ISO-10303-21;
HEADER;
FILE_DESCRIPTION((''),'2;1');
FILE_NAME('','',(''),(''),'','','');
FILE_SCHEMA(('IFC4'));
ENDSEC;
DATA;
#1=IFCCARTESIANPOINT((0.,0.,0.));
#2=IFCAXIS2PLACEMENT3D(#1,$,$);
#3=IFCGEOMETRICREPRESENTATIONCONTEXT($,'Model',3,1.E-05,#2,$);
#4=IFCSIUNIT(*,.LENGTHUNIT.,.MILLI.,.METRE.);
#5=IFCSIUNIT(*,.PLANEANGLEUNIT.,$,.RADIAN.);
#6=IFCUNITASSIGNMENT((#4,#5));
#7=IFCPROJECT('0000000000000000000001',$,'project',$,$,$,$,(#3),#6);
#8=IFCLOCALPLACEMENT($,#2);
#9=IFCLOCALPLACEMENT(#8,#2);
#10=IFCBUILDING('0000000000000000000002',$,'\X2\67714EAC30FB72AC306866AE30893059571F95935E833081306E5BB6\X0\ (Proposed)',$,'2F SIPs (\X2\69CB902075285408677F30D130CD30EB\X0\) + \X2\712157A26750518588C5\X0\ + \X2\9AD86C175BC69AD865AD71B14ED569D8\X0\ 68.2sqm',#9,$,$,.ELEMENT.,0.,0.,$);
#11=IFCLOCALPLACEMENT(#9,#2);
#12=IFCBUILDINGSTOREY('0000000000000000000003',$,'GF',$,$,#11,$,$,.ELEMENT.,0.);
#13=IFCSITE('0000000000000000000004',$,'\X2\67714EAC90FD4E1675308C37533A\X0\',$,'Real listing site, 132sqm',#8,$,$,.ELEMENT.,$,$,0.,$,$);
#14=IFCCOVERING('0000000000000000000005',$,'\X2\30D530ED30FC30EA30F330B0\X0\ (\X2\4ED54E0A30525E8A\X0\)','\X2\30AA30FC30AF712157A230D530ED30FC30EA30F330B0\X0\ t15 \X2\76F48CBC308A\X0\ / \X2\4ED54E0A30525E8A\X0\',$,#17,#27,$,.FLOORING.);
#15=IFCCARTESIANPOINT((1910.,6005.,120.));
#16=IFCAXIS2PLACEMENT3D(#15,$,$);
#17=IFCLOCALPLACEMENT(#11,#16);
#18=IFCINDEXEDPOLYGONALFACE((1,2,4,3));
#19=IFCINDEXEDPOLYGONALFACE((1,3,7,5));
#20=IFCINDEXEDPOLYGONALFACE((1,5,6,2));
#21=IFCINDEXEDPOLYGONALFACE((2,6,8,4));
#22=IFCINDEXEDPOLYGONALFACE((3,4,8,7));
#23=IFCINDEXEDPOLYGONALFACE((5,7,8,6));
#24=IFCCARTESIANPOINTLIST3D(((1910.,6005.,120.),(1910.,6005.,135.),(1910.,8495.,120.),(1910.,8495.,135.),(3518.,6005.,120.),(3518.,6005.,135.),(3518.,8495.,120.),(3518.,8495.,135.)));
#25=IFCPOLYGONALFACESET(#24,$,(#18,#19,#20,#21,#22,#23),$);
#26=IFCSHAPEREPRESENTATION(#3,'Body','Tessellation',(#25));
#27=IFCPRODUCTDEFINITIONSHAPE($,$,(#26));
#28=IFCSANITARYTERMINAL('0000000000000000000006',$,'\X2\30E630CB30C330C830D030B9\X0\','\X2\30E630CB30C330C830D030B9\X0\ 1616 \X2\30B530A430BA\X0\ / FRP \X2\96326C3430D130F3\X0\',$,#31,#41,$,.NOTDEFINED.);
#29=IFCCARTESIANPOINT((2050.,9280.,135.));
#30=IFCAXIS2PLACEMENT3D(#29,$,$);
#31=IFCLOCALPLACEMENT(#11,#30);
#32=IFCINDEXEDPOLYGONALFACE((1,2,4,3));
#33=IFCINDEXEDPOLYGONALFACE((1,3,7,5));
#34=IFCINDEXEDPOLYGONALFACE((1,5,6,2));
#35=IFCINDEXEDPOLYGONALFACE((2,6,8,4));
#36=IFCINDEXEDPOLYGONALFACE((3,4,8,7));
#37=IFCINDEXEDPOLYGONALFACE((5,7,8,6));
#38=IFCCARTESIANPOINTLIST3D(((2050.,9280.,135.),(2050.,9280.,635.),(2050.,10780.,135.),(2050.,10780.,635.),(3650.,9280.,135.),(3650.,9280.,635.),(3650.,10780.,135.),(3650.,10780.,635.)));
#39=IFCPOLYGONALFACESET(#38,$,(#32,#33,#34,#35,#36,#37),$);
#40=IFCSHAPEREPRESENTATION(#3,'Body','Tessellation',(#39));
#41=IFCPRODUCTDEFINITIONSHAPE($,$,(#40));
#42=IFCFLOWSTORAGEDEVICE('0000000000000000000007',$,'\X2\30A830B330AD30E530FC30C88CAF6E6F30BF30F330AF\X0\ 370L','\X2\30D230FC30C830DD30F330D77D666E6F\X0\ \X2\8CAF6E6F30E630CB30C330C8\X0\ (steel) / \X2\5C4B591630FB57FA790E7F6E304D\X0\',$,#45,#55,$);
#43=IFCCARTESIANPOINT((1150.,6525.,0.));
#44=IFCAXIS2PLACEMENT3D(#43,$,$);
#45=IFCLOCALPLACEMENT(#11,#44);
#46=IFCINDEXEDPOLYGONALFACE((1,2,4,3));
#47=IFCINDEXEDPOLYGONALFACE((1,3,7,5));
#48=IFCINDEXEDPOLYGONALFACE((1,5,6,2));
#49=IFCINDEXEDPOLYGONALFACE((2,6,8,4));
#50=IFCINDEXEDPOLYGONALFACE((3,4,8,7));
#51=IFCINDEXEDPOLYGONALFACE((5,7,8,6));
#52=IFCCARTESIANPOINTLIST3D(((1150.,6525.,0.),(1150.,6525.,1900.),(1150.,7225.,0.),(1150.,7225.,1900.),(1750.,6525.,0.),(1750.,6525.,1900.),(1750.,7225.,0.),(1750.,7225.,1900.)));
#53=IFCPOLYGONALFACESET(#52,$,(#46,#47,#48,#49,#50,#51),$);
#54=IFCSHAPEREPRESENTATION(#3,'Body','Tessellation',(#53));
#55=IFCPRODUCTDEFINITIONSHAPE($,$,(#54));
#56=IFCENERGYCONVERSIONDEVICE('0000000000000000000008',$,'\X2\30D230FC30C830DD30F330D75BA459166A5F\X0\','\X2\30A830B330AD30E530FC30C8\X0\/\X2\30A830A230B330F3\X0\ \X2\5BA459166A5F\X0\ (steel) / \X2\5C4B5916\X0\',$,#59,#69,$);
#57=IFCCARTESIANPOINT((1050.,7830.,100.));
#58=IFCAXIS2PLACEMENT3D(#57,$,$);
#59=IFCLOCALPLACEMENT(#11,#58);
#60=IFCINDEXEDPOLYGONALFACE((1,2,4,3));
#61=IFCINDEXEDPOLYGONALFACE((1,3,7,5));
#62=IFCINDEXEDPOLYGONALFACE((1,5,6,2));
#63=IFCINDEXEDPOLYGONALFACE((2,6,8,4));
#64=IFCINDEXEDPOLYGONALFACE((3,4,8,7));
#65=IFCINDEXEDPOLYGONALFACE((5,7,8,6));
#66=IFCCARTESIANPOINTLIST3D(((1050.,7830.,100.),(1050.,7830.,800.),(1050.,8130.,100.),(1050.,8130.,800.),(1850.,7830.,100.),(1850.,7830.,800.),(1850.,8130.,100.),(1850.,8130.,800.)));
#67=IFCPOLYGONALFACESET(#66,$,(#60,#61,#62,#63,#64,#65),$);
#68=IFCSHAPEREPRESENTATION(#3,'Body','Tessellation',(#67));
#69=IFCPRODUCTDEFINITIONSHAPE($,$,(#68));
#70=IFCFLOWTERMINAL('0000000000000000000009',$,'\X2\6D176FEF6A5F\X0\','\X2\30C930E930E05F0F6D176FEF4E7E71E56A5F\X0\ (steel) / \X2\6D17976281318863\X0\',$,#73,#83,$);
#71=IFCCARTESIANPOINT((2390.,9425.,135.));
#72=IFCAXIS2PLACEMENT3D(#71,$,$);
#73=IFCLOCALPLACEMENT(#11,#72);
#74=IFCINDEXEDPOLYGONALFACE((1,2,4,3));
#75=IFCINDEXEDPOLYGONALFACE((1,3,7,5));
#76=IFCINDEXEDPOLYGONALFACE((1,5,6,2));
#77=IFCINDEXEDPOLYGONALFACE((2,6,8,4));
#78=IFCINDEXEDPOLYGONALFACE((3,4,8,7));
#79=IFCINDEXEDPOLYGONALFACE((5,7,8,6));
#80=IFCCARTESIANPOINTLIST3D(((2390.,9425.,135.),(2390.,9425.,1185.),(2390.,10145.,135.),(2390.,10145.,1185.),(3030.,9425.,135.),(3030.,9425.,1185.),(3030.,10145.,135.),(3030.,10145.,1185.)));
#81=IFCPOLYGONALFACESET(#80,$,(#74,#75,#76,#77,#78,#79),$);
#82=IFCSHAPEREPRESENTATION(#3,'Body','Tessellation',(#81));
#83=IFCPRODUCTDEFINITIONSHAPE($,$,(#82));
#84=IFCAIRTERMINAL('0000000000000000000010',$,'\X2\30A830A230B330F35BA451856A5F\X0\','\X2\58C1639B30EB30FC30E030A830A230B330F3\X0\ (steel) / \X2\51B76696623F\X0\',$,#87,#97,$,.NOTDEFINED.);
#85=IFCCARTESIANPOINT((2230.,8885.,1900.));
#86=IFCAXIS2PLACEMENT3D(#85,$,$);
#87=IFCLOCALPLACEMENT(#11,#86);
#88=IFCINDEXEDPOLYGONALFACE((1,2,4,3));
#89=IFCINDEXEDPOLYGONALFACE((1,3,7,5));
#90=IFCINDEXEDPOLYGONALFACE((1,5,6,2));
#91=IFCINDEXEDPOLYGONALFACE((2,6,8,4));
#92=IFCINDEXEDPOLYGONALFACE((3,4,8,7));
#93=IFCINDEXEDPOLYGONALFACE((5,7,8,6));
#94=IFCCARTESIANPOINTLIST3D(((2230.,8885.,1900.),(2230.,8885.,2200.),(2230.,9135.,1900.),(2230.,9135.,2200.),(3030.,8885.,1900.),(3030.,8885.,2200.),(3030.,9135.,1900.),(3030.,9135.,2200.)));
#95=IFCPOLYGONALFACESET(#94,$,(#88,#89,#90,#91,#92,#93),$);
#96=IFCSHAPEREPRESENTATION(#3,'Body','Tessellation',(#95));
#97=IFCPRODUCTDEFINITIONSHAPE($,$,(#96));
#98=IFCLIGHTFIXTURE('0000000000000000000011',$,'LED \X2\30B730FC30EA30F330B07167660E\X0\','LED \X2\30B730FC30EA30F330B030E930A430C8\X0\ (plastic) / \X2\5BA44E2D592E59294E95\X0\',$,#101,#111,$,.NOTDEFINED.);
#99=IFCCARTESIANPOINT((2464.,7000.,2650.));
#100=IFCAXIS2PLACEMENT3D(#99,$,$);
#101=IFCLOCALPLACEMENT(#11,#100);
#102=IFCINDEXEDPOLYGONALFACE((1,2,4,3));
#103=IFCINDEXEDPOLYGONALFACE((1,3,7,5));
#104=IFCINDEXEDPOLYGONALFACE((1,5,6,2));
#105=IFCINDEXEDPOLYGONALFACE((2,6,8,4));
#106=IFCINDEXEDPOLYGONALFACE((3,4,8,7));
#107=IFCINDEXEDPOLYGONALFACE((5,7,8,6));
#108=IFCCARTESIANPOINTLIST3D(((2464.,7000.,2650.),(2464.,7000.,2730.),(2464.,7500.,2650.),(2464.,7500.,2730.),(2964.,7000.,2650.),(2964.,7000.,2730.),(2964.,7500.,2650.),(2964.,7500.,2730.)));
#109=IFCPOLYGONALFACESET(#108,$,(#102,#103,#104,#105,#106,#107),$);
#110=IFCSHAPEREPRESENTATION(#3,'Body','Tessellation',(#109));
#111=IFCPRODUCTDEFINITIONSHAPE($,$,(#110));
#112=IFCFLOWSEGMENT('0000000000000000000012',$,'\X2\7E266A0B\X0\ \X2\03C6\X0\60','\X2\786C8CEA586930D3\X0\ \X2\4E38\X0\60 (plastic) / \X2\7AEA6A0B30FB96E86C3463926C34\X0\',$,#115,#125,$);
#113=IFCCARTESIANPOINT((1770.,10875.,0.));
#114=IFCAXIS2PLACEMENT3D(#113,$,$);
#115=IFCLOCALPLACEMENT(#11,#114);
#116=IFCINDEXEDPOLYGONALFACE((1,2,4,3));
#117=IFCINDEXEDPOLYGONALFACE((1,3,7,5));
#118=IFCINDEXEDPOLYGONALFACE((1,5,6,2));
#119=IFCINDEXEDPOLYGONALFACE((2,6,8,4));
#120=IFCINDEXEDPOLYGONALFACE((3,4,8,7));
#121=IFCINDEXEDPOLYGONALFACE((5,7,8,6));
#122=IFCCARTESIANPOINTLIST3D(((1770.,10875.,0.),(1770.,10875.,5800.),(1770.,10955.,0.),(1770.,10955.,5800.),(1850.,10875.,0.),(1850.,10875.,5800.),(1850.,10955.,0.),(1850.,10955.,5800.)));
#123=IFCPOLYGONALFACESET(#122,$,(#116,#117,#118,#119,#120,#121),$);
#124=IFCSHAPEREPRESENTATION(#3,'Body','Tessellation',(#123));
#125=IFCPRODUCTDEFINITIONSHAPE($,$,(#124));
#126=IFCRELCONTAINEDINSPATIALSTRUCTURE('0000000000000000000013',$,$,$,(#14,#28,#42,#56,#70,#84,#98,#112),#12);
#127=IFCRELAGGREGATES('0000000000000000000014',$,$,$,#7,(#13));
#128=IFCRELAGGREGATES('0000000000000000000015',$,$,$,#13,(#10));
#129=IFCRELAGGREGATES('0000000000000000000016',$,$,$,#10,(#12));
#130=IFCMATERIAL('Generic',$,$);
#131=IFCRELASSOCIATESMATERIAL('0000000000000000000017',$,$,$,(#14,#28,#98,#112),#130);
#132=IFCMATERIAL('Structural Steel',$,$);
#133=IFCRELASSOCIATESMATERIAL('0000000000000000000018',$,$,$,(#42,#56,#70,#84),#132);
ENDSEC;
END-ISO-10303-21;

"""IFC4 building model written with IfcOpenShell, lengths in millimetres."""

from ifc_helpers import new_model, si_unit, frame, frame_2d, origin, place, context, project, spatial, rectangle, extrude, material, element, save


model = new_model("IFC4")

# Units and contexts
model_context = context("Model", 3, precision=1e-05, world=origin())
ifc_project = project(units=[si_unit("LENGTHUNIT", "METRE", prefix="MILLI"), si_unit("PLANEANGLEUNIT", "RADIAN")], contexts=[model_context])

# Site, building, storey
site_placement = place(None, origin())
site = spatial("IfcSite", under=ifc_project, at=site_placement, Name="東京都世田谷区", ObjectType="Real listing site, 132sqm", CompositionType="ELEMENT", RefElevation=0.0)
building_placement = place(site_placement, origin())
building = spatial("IfcBuilding", under=site, at=building_placement, Name="東京・犬と暮らす土間広めの家 (Proposed)", ObjectType="2F SIPs (構造用合板パネル) + 無垢材内装 + 高気密高断熱仕様 68.2sqm", CompositionType="ELEMENT", ElevationOfRefHeight=0.0, ElevationOfTerrain=0.0)
storey_placement = place(building_placement, origin())
storey = spatial("IfcBuildingStorey", under=building, at=storey_placement, Name="GF", CompositionType="ELEMENT", Elevation=0.0)

# Covering
ifc_material_1 = material(Name="Generic")
covering_1_placement = place(storey_placement, frame((1910.0, 6005.0, 120.0)))
element("IfcCovering", 1, at=covering_1_placement, inside=storey, material=ifc_material_1, Name="フローリング (仕上げ床)", Description="オーク無垢フローリング t15 直貼り / 仕上げ床", PredefinedType="FLOORING", context=model_context, shape_type="SweptSolid", body=[
    extrude(rectangle(XDim=1608.0, YDim=2490.0, at=frame_2d((804.0, 1245.0))), frame((1910.0, 6005.0, 120.0)), (0.0, 0.0, 1.0), 15.0),
])

# Sanitary terminal
sanitary_terminal_placement = place(storey_placement, frame((2050.0, 9280.0, 135.0)))
element("IfcSanitaryTerminal", 2, at=sanitary_terminal_placement, inside=storey, material=ifc_material_1, Name="ユニットバス", Description="ユニットバス 1616 サイズ / FRP 防水パン", PredefinedType="NOTDEFINED", context=model_context, shape_type="SweptSolid", body=[
    extrude(rectangle(XDim=1600.0, YDim=1500.0, at=frame_2d((800.0, 750.0))), frame((2050.0, 9280.0, 135.0)), (0.0, 0.0, 1.0), 500.0),
])

# Flow storage device
ifc_material_2 = material(Name="Structural Steel")
flow_storage_device_placement = place(storey_placement, frame((1150.0, 6525.0, 0.0)))
element("IfcFlowStorageDevice", 3, at=flow_storage_device_placement, inside=storey, material=ifc_material_2, Name="エコキュート貯湯タンク 370L", Description="ヒートポンプ給湯 貯湯ユニット (steel) / 屋外・基礎置き", context=model_context, shape_type="SweptSolid", body=[
    extrude(rectangle(XDim=600.0, YDim=700.0, at=frame_2d((300.0, 350.0))), frame((1150.0, 6525.0, 0.0)), (0.0, 0.0, 1.0), 1900.0),
])

# Energy conversion device
energy_conversion_device_placement = place(storey_placement, frame((1050.0, 7830.0, 100.0)))
element("IfcEnergyConversionDevice", 4, at=energy_conversion_device_placement, inside=storey, material=ifc_material_2, Name="ヒートポンプ室外機", Description="エコキュート/エアコン 室外機 (steel) / 屋外", context=model_context, shape_type="SweptSolid", body=[
    extrude(rectangle(XDim=800.0, YDim=300.0, at=frame_2d((400.0, 150.0))), frame((1050.0, 7830.0, 100.0)), (0.0, 0.0, 1.0), 700.0),
])

# Flow terminal
flow_terminal_placement = place(storey_placement, frame((2390.0, 9425.0, 135.0)))
element("IfcFlowTerminal", 5, at=flow_terminal_placement, inside=storey, material=ifc_material_2, Name="洗濯機", Description="ドラム式洗濯乾燥機 (steel) / 洗面脱衣", context=model_context, shape_type="SweptSolid", body=[
    extrude(rectangle(XDim=640.0, YDim=720.0, at=frame_2d((320.0, 360.0))), frame((2390.0, 9425.0, 135.0)), (0.0, 0.0, 1.0), 1050.0),
])

# Air terminal
air_terminal_placement = place(storey_placement, frame((2230.0, 8885.0, 1900.0)))
element("IfcAirTerminal", 6, at=air_terminal_placement, inside=storey, material=ifc_material_2, Name="エアコン室内機", Description="壁掛ルームエアコン (steel) / 冷暖房", PredefinedType="NOTDEFINED", context=model_context, shape_type="SweptSolid", body=[
    extrude(rectangle(XDim=800.0, YDim=250.0, at=frame_2d((400.0, 125.0))), frame((2230.0, 8885.0, 1900.0)), (0.0, 0.0, 1.0), 300.0),
])

# Light fixture
light_fixture_placement = place(storey_placement, frame((2464.0, 7000.0, 2650.0)))
element("IfcLightFixture", 7, at=light_fixture_placement, inside=storey, material=ifc_material_1, Name="LED シーリング照明", Description="LED シーリングライト (plastic) / 室中央天井", PredefinedType="NOTDEFINED", context=model_context, shape_type="SweptSolid", body=[
    extrude(rectangle(XDim=500.0, YDim=500.0, at=frame_2d((250.0, 250.0))), frame((2464.0, 7000.0, 2650.0)), (0.0, 0.0, 1.0), 80.0),
])

# Flow segment
flow_segment_placement = place(storey_placement, frame((1770.0, 10875.0, 0.0)))
element("IfcFlowSegment", 8, at=flow_segment_placement, inside=storey, material=ifc_material_1, Name="縦樋 φ60", Description="硬質塩ビ 丸60 (plastic) / 竪樋・雨水排水", context=model_context, shape_type="SweptSolid", body=[
    extrude(rectangle(XDim=80.0, YDim=80.0, at=frame_2d((40.0, 40.0))), frame((1770.0, 10875.0, 0.0)), (0.0, 0.0, 1.0), 5800.0),
])

save(model, "model.ifc")
